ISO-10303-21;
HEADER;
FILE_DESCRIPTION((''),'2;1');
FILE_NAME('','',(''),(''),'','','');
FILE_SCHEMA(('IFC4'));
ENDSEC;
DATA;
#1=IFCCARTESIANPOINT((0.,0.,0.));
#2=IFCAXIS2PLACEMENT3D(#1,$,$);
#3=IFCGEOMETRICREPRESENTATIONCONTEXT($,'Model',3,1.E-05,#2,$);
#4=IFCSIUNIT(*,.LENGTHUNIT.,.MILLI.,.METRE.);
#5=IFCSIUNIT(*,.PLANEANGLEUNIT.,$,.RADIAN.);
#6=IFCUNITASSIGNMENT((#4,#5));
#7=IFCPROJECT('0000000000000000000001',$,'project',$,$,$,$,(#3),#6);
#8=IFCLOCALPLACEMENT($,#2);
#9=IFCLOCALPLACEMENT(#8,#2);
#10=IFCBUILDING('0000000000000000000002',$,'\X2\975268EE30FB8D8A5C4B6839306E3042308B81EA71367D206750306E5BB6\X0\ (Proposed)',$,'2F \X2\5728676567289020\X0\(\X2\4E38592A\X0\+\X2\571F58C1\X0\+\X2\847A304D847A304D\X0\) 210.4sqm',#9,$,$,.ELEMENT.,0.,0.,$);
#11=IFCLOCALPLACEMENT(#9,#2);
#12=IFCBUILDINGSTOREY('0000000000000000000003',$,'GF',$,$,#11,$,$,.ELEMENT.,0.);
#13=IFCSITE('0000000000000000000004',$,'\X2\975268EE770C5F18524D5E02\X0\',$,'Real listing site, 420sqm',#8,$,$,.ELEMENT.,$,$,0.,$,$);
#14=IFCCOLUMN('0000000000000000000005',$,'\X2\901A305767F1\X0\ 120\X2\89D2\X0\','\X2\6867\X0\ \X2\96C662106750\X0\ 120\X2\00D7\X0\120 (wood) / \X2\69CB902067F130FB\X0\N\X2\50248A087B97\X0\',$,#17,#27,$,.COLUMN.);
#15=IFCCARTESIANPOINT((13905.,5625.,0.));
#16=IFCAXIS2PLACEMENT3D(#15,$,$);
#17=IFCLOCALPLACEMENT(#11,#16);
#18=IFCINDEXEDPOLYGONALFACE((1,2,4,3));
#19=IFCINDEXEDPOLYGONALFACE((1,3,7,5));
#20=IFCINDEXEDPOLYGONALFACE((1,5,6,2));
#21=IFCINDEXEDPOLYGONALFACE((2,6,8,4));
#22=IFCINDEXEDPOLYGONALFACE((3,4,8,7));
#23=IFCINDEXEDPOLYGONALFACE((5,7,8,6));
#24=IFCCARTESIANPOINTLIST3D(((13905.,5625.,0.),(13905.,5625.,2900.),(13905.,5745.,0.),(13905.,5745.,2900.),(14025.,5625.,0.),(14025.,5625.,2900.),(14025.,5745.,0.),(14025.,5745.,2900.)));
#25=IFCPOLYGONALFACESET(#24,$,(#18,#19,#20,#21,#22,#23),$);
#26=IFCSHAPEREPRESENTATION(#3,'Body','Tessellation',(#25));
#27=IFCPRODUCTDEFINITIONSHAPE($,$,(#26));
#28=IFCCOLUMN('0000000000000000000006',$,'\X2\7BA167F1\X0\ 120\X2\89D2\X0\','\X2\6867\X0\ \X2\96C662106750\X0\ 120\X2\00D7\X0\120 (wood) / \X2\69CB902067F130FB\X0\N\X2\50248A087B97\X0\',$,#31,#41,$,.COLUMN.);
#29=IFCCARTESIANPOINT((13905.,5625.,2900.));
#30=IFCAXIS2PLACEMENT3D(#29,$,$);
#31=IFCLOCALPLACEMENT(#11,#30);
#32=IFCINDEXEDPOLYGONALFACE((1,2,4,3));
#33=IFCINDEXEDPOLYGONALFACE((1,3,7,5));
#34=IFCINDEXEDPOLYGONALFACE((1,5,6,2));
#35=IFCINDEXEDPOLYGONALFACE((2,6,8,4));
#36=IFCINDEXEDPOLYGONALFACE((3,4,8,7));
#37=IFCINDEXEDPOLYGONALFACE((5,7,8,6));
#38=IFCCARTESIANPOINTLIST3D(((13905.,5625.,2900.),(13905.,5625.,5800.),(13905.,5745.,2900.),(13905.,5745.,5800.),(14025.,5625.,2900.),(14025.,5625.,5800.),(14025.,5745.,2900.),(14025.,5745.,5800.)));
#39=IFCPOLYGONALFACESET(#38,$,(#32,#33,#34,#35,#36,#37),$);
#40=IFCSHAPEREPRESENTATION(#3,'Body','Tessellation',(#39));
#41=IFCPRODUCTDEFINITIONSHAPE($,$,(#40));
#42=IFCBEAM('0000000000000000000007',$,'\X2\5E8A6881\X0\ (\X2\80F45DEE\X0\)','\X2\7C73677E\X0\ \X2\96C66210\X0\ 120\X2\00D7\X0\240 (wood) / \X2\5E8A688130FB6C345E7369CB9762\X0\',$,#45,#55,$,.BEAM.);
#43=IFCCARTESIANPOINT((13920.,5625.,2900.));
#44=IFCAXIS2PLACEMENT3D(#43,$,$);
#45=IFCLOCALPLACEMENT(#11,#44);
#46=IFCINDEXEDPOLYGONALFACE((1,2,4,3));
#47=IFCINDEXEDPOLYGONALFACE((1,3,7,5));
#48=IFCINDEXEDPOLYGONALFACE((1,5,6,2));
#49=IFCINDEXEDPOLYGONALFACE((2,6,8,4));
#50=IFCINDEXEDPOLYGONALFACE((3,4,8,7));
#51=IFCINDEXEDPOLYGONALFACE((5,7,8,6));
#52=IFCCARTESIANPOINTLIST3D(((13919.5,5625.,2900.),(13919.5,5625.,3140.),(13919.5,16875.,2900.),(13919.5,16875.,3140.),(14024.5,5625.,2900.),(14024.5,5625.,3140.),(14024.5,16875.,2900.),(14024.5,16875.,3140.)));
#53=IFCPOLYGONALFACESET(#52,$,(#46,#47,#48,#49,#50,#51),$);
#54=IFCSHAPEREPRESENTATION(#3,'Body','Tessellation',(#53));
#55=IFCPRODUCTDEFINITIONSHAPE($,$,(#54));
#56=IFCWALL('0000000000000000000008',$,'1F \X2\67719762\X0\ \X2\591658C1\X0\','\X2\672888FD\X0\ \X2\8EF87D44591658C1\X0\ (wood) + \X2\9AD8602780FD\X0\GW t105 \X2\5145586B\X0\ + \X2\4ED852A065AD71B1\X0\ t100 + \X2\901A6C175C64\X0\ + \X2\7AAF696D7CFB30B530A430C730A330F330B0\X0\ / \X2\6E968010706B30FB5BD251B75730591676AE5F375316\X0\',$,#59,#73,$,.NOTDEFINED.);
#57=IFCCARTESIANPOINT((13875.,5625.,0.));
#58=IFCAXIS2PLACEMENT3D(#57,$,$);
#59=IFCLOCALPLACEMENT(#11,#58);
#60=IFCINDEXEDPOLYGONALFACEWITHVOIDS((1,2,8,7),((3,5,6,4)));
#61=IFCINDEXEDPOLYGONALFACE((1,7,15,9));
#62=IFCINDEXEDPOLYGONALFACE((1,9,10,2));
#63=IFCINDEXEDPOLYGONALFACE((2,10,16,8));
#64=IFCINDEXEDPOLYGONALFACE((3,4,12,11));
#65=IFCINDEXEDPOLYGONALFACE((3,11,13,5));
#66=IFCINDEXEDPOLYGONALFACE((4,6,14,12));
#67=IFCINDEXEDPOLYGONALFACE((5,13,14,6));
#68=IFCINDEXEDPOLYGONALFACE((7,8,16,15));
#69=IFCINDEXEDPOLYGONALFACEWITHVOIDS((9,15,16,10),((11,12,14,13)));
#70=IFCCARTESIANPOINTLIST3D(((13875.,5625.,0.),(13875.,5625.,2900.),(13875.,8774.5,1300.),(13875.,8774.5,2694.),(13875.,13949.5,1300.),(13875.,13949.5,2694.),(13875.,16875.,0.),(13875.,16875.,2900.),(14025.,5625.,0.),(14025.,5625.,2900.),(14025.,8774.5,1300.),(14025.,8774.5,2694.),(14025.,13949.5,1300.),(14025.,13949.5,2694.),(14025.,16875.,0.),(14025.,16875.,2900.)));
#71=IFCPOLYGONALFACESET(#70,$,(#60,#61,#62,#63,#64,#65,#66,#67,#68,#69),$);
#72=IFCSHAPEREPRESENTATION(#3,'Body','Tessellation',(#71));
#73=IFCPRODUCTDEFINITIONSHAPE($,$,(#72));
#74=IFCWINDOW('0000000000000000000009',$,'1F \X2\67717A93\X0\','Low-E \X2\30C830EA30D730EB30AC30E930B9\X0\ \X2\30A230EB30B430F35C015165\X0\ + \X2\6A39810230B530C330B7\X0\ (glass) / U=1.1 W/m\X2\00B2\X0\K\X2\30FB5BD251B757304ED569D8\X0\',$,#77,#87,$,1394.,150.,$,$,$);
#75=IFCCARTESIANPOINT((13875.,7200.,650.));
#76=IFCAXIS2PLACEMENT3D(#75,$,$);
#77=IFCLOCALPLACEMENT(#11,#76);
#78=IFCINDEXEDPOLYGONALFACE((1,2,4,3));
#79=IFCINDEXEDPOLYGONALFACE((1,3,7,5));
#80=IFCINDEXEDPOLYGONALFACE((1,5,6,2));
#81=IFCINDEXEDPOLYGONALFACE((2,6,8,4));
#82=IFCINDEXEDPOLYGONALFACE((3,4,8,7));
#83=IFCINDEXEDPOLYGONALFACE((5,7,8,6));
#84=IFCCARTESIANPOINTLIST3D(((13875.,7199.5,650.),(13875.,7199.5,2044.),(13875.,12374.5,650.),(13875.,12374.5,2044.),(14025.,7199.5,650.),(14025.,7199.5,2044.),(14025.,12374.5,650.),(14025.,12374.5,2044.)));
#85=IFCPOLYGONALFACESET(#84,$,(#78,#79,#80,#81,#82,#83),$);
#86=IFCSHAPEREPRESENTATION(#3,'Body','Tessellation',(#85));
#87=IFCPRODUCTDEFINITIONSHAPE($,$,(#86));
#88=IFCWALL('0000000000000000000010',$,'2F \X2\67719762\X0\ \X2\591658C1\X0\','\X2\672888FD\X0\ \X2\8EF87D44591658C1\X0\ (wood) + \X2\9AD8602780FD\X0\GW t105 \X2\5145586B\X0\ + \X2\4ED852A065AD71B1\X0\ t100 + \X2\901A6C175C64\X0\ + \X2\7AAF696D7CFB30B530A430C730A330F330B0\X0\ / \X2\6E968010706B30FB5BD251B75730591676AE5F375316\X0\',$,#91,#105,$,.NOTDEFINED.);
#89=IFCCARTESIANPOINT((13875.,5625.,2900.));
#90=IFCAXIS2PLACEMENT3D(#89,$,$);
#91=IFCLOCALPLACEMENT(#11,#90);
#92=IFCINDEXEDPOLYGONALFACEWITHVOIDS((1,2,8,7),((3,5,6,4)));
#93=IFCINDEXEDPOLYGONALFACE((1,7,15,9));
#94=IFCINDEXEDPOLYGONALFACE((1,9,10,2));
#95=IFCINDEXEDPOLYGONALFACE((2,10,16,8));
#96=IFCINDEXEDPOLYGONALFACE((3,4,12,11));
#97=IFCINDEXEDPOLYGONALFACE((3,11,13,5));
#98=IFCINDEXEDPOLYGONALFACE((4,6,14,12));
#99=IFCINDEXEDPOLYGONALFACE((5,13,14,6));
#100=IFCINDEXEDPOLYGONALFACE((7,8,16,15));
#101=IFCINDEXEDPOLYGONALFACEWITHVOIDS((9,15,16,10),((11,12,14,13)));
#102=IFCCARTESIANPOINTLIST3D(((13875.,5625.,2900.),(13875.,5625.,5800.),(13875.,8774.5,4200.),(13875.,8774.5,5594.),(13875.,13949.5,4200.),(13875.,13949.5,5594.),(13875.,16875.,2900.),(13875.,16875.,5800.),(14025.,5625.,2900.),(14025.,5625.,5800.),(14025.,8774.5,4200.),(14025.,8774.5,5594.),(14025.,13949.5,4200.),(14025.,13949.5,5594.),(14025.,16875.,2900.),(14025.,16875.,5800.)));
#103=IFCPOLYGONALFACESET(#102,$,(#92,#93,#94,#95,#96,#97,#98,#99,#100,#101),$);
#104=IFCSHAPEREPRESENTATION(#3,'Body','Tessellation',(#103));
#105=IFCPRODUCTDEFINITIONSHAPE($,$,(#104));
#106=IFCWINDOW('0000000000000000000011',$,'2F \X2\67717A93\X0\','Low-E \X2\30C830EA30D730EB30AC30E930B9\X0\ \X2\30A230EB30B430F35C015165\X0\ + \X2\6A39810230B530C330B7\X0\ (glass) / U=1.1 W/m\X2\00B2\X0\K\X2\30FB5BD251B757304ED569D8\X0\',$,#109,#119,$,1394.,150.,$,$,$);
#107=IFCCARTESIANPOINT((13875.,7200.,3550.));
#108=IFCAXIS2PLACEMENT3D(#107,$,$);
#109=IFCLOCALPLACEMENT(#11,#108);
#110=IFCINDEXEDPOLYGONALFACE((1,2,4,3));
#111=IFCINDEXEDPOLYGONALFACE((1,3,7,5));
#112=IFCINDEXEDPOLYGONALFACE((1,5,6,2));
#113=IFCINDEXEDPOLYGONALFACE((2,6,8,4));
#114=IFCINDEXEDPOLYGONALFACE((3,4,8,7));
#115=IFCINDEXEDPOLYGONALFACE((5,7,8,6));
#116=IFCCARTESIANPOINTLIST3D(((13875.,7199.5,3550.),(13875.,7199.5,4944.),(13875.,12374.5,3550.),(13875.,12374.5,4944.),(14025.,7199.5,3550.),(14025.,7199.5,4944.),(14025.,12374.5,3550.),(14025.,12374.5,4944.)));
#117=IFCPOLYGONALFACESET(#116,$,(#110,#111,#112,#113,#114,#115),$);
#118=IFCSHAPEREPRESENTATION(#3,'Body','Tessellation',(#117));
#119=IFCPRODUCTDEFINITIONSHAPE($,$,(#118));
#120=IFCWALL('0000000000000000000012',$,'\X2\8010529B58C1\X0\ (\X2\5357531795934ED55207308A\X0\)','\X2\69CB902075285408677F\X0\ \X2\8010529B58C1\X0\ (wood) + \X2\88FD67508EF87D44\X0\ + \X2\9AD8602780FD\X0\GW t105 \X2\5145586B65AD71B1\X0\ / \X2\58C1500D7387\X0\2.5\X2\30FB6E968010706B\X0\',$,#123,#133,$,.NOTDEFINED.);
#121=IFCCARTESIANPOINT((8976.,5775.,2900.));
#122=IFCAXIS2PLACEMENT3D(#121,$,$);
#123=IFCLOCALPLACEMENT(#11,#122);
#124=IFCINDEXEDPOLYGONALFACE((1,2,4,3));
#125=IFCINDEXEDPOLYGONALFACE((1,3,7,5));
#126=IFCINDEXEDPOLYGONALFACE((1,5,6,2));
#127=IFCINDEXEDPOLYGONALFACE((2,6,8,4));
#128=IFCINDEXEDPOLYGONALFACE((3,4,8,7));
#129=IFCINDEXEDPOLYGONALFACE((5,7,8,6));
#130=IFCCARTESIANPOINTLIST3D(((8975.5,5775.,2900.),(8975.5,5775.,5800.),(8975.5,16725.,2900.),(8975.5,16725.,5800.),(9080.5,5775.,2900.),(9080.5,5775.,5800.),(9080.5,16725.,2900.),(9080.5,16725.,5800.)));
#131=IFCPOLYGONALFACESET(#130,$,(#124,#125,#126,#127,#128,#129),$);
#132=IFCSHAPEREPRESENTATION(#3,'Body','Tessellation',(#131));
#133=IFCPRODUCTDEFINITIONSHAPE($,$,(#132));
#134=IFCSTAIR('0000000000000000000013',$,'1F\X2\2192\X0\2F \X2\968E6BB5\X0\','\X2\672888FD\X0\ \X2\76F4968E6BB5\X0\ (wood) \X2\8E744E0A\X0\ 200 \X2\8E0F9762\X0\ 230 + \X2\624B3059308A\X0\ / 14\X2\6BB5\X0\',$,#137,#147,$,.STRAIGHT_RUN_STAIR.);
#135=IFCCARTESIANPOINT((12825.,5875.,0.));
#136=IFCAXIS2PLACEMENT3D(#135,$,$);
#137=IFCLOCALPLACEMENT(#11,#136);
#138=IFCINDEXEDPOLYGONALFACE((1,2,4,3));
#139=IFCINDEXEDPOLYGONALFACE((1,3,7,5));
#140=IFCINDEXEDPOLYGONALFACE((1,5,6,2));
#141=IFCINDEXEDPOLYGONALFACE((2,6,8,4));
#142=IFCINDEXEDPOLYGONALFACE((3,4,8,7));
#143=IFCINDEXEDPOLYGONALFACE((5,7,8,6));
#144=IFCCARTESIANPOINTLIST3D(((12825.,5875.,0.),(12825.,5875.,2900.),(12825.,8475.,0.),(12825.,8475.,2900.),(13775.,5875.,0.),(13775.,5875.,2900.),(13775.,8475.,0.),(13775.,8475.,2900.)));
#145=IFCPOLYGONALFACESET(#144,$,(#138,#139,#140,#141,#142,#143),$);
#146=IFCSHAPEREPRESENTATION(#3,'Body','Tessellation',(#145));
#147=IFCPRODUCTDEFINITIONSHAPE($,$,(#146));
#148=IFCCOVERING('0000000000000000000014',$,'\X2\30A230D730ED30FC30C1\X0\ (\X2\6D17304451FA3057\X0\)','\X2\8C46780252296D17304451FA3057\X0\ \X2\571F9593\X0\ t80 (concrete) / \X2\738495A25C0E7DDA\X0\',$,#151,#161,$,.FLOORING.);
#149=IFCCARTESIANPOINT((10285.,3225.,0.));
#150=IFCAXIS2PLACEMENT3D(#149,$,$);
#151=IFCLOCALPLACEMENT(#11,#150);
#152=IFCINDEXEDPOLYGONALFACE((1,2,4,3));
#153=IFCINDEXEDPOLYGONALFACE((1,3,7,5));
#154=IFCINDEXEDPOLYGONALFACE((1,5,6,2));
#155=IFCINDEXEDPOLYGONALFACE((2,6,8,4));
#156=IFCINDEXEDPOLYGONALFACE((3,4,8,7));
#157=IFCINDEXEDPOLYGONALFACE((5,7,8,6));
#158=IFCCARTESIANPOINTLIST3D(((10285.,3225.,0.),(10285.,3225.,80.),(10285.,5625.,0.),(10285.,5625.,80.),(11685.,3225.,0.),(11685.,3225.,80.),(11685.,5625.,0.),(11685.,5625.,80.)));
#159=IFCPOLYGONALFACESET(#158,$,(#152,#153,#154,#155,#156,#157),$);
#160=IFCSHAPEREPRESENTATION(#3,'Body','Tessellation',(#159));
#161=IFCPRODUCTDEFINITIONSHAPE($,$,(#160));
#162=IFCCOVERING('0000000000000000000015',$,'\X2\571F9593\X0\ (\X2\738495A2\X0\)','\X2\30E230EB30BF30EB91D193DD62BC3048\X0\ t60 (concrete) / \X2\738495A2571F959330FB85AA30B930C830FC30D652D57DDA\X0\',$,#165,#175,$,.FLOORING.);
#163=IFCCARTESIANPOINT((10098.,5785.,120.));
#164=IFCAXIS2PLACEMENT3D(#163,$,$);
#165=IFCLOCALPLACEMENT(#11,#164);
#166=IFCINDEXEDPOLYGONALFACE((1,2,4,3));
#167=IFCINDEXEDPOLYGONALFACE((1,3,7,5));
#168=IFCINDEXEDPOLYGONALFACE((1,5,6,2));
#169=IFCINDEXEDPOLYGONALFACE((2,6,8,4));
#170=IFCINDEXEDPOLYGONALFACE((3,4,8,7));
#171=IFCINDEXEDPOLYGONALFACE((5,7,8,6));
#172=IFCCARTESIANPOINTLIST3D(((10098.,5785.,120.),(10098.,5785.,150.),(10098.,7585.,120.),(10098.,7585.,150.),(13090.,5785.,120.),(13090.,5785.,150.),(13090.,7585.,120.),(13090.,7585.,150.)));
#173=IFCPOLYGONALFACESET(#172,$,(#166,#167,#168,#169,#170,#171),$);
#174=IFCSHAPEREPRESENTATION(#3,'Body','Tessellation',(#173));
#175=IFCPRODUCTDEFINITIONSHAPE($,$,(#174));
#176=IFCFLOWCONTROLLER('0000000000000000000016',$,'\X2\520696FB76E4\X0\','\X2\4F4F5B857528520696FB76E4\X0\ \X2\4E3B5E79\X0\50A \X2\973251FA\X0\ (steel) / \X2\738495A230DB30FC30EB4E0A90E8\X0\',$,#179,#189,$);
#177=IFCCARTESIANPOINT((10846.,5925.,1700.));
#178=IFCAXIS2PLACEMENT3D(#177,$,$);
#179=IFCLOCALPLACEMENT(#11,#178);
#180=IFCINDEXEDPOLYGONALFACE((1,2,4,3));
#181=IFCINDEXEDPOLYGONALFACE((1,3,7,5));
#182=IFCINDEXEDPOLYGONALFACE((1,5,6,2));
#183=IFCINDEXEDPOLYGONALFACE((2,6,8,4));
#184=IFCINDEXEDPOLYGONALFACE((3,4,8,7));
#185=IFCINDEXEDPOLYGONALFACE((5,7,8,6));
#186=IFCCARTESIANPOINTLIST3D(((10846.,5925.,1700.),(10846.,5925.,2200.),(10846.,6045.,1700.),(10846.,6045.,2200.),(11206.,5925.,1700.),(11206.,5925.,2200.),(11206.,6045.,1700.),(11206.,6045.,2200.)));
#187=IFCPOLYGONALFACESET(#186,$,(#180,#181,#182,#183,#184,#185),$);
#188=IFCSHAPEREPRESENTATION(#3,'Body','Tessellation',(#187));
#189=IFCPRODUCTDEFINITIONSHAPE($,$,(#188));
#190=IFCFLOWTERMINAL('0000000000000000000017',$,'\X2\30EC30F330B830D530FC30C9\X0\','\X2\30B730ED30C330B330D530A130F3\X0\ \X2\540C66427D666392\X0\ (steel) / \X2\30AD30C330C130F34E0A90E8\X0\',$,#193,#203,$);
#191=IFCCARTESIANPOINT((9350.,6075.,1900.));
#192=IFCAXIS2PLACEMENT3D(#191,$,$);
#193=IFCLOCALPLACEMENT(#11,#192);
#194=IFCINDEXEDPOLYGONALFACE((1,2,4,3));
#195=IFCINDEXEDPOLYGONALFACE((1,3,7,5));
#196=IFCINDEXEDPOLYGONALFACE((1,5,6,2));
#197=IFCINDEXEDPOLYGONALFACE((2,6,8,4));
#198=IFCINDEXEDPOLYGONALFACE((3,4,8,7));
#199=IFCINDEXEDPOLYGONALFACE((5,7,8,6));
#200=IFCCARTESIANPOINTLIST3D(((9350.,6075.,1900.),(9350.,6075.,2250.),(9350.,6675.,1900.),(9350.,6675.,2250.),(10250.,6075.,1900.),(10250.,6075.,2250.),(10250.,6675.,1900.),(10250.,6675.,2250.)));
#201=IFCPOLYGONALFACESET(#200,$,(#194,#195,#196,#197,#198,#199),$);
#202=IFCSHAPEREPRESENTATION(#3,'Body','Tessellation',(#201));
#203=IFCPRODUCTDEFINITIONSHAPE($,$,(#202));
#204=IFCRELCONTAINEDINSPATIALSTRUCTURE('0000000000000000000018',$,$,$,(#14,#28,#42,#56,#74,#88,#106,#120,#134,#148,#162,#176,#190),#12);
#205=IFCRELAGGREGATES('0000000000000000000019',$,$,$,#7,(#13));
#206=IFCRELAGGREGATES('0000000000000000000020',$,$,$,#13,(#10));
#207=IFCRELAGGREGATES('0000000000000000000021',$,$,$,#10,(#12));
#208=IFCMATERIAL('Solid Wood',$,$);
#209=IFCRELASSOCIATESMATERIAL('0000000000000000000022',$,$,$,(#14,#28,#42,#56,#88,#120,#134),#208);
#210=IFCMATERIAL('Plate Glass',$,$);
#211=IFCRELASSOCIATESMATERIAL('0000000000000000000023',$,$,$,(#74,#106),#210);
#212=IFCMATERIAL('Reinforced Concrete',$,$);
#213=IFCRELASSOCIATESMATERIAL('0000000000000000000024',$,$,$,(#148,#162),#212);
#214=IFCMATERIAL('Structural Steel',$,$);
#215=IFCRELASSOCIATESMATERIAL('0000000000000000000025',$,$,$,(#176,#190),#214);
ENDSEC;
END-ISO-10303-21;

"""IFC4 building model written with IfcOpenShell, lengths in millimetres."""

from ifc_helpers import new_model, si_unit, frame, frame_2d, origin, place, context, project, spatial, rectangle, extrude, material, element, fill, save


model = new_model("IFC4")

# Units and contexts
model_context = context("Model", 3, precision=1e-05, world=origin())
ifc_project = project(units=[si_unit("LENGTHUNIT", "METRE", prefix="MILLI"), si_unit("PLANEANGLEUNIT", "RADIAN")], contexts=[model_context])

# Site, building, storey
site_placement = place(None, origin())
site = spatial("IfcSite", under=ifc_project, at=site_placement, Name="青森県弘前市", ObjectType="Real listing site, 420sqm", CompositionType="ELEMENT", RefElevation=0.0)
building_placement = place(site_placement, origin())
building = spatial("IfcBuilding", under=site, at=building_placement, Name="青森・越屋根のある自然素材の家 (Proposed)", ObjectType="2F 在来木造(丸太+土壁+葺き葺き) 210.4sqm", CompositionType="ELEMENT", ElevationOfRefHeight=0.0, ElevationOfTerrain=0.0)
storey_placement = place(building_placement, origin())
storey = spatial("IfcBuildingStorey", under=building, at=storey_placement, Name="GF", CompositionType="ELEMENT", Elevation=0.0)

# Columns
ifc_material_1 = material(Name="Solid Wood")
column_1_placement = place(storey_placement, frame((13905.0, 5625.0, 0.0)))
element("IfcColumn", 1, at=column_1_placement, inside=storey, material=ifc_material_1, Name="通し柱 120角", Description="桧 集成材 120×120 (wood) / 構造柱・N値計算", PredefinedType="COLUMN", context=model_context, shape_type="SweptSolid", body=[
    extrude(rectangle(XDim=120.0, YDim=120.0, at=frame_2d((60.0, 60.0))), frame((13905.0, 5625.0, 0.0)), (0.0, 0.0, 1.0), 2900.0),
])
column_2_placement = place(storey_placement, frame((13905.0, 5625.0, 2900.0)))
element("IfcColumn", 2, at=column_2_placement, inside=storey, material=ifc_material_1, Name="管柱 120角", Description="桧 集成材 120×120 (wood) / 構造柱・N値計算", PredefinedType="COLUMN", context=model_context, shape_type="SweptSolid", body=[
    extrude(rectangle(XDim=120.0, YDim=120.0, at=frame_2d((60.0, 60.0))), frame((13905.0, 5625.0, 2900.0)), (0.0, 0.0, 1.0), 2900.0),
])

# Beam
beam_1_placement = place(storey_placement, frame((13920.0, 5625.0, 2900.0)))
element("IfcBeam", 3, at=beam_1_placement, inside=storey, material=ifc_material_1, Name="床梁 (胴差)", Description="米松 集成 120×240 (wood) / 床梁・水平構面", PredefinedType="BEAM", context=model_context, shape_type="SweptSolid", body=[
    extrude(rectangle(XDim=105.0, YDim=11250.0, at=frame_2d((52.0, 5625.0))), frame((13920.0, 5625.0, 2900.0)), (0.0, 0.0, 1.0), 240.0),
])

# Wall, opening, window
wall_1_placement = place(storey_placement, frame((13875.0, 5625.0, 0.0)))
wall_1 = element("IfcWall", 4, at=wall_1_placement, inside=storey, material=ifc_material_1, Name="1F 東面 外壁", Description="木製 軸組外壁 (wood) + 高性能GW t105 充填 + 付加断熱 t100 + 通気層 + 窯業系サイディング / 準耐火・寒冷地外皮強化", PredefinedType="NOTDEFINED", context=model_context, shape_type="SweptSolid", body=[
    extrude(rectangle(XDim=150.0, YDim=11250.0, at=frame_2d((75.0, 5625.0))), frame((13875.0, 5625.0, 0.0)), (0.0, 0.0, 1.0), 2900.0),
])
opening_1_placement = place(storey_placement, frame((13875.0, 7200.0, 650.0)))
opening_1 = element("IfcOpeningElement", 5, at=opening_1_placement, cuts=wall_1, PredefinedType="NOTDEFINED", context=model_context, shape_type="SweptSolid", body=[
    extrude(rectangle(XDim=150.0, YDim=5175.0, at=frame_2d((75.0, 2587.0))), frame((13875.0, 7200.0, 650.0)), (0.0, 0.0, 1.0), 1394.0),
])
ifc_material_2 = material(Name="Plate Glass")
window_1_placement = place(storey_placement, frame((13875.0, 7200.0, 650.0)))
window_1 = element("IfcWindow", 6, at=window_1_placement, inside=storey, material=ifc_material_2, Name="1F 東窓", Description="Low-E トリプルガラス アルゴン封入 + 樹脂サッシ (glass) / U=1.1 W/m²K・寒冷地仕様", OverallHeight=1394.0, OverallWidth=150.0, context=model_context, shape_type="SweptSolid", body=[
    extrude(rectangle(XDim=150.0, YDim=5175.0, at=frame_2d((75.0, 2587.0))), frame((13875.0, 7200.0, 650.0)), (0.0, 0.0, 1.0), 1394.0),
])
fill(opening_1, window_1)

# Wall, opening, window
wall_2_placement = place(storey_placement, frame((13875.0, 5625.0, 2900.0)))
wall_2 = element("IfcWall", 7, at=wall_2_placement, inside=storey, material=ifc_material_1, Name="2F 東面 外壁", Description="木製 軸組外壁 (wood) + 高性能GW t105 充填 + 付加断熱 t100 + 通気層 + 窯業系サイディング / 準耐火・寒冷地外皮強化", PredefinedType="NOTDEFINED", context=model_context, shape_type="SweptSolid", body=[
    extrude(rectangle(XDim=150.0, YDim=11250.0, at=frame_2d((75.0, 5625.0))), frame((13875.0, 5625.0, 2900.0)), (0.0, 0.0, 1.0), 2900.0),
])
opening_2_placement = place(storey_placement, frame((13875.0, 7200.0, 3550.0)))
opening_2 = element("IfcOpeningElement", 8, at=opening_2_placement, cuts=wall_2, PredefinedType="NOTDEFINED", context=model_context, shape_type="SweptSolid", body=[
    extrude(rectangle(XDim=150.0, YDim=5175.0, at=frame_2d((75.0, 2587.0))), frame((13875.0, 7200.0, 3550.0)), (0.0, 0.0, 1.0), 1394.0),
])
window_2_placement = place(storey_placement, frame((13875.0, 7200.0, 3550.0)))
window_2 = element("IfcWindow", 9, at=window_2_placement, inside=storey, material=ifc_material_2, Name="2F 東窓", Description="Low-E トリプルガラス アルゴン封入 + 樹脂サッシ (glass) / U=1.1 W/m²K・寒冷地仕様", OverallHeight=1394.0, OverallWidth=150.0, context=model_context, shape_type="SweptSolid", body=[
    extrude(rectangle(XDim=150.0, YDim=5175.0, at=frame_2d((75.0, 2587.0))), frame((13875.0, 7200.0, 3550.0)), (0.0, 0.0, 1.0), 1394.0),
])
fill(opening_2, window_2)

# Wall
wall_3_placement = place(storey_placement, frame((8976.0, 5775.0, 2900.0)))
element("IfcWall", 10, at=wall_3_placement, inside=storey, material=ifc_material_1, Name="耐力壁 (南北間仕切り)", Description="構造用合板 耐力壁 (wood) + 製材軸組 + 高性能GW t105 充填断熱 / 壁倍率2.5・準耐火", PredefinedType="NOTDEFINED", context=model_context, shape_type="SweptSolid", body=[
    extrude(rectangle(XDim=105.0, YDim=10950.0, at=frame_2d((52.0, 5475.0))), frame((8976.0, 5775.0, 2900.0)), (0.0, 0.0, 1.0), 2900.0),
])

# Stair
stair_placement = place(storey_placement, frame((12825.0, 5875.0, 0.0)))
element("IfcStair", 11, at=stair_placement, inside=storey, material=ifc_material_1, Name="1F→2F 階段", Description="木製 直階段 (wood) 蹴上 200 踏面 230 + 手すり / 14段", PredefinedType="STRAIGHT_RUN_STAIR", context=model_context, shape_type="SweptSolid", body=[
    extrude(rectangle(XDim=950.0, YDim=2600.0, at=frame_2d((475.0, 1300.0))), frame((12825.0, 5875.0, 0.0)), (0.0, 0.0, 1.0), 2900.0),
])

# Coverings
ifc_material_3 = material(Name="Reinforced Concrete")
covering_1_placement = place(storey_placement, frame((10285.0, 3225.0, 0.0)))
element("IfcCovering", 12, at=covering_1_placement, inside=storey, material=ifc_material_3, Name="アプローチ (洗い出し)", Description="豆砂利洗い出し 土間 t80 (concrete) / 玄関導線", PredefinedType="FLOORING", context=model_context, shape_type="SweptSolid", body=[
    extrude(rectangle(XDim=1400.0, YDim=2400.0, at=frame_2d((700.0, 1200.0))), frame((10285.0, 3225.0, 0.0)), (0.0, 0.0, 1.0), 80.0),
])
covering_2_placement = place(storey_placement, frame((10098.0, 5785.0, 120.0)))
element("IfcCovering", 13, at=covering_2_placement, inside=storey, material=ifc_material_3, Name="土間 (玄関)", Description="モルタル金鏝押え t60 (concrete) / 玄関土間・薪ストーブ動線", PredefinedType="FLOORING", context=model_context, shape_type="SweptSolid", body=[
    extrude(rectangle(XDim=2992.0, YDim=1800.0, at=frame_2d((1496.0, 900.0))), frame((10098.0, 5785.0, 120.0)), (0.0, 0.0, 1.0), 30.0),
])

# Flow controller
ifc_material_4 = material(Name="Structural Steel")
flow_controller_placement = place(storey_placement, frame((10846.0, 5925.0, 1700.0)))
element("IfcFlowController", 14, at=flow_controller_placement, inside=storey, material=ifc_material_4, Name="分電盤", Description="住宅用分電盤 主幹50A 露出 (steel) / 玄関ホール上部", context=model_context, shape_type="SweptSolid", body=[
    extrude(rectangle(XDim=360.0, YDim=120.0, at=frame_2d((180.0, 60.0))), frame((10846.0, 5925.0, 1700.0)), (0.0, 0.0, 1.0), 500.0),
])

# Flow terminal
flow_terminal_1_placement = place(storey_placement, frame((9350.0, 6075.0, 1900.0)))
element("IfcFlowTerminal", 15, at=flow_terminal_1_placement, inside=storey, material=ifc_material_4, Name="レンジフード", Description="シロッコファン 同時給排 (steel) / キッチン上部", context=model_context, shape_type="SweptSolid", body=[
    extrude(rectangle(XDim=900.0, YDim=600.0, at=frame_2d((450.0, 300.0))), frame((9350.0, 6075.0, 1900.0)), (0.0, 0.0, 1.0), 350.0),
])

save(model, "model.ifc")
